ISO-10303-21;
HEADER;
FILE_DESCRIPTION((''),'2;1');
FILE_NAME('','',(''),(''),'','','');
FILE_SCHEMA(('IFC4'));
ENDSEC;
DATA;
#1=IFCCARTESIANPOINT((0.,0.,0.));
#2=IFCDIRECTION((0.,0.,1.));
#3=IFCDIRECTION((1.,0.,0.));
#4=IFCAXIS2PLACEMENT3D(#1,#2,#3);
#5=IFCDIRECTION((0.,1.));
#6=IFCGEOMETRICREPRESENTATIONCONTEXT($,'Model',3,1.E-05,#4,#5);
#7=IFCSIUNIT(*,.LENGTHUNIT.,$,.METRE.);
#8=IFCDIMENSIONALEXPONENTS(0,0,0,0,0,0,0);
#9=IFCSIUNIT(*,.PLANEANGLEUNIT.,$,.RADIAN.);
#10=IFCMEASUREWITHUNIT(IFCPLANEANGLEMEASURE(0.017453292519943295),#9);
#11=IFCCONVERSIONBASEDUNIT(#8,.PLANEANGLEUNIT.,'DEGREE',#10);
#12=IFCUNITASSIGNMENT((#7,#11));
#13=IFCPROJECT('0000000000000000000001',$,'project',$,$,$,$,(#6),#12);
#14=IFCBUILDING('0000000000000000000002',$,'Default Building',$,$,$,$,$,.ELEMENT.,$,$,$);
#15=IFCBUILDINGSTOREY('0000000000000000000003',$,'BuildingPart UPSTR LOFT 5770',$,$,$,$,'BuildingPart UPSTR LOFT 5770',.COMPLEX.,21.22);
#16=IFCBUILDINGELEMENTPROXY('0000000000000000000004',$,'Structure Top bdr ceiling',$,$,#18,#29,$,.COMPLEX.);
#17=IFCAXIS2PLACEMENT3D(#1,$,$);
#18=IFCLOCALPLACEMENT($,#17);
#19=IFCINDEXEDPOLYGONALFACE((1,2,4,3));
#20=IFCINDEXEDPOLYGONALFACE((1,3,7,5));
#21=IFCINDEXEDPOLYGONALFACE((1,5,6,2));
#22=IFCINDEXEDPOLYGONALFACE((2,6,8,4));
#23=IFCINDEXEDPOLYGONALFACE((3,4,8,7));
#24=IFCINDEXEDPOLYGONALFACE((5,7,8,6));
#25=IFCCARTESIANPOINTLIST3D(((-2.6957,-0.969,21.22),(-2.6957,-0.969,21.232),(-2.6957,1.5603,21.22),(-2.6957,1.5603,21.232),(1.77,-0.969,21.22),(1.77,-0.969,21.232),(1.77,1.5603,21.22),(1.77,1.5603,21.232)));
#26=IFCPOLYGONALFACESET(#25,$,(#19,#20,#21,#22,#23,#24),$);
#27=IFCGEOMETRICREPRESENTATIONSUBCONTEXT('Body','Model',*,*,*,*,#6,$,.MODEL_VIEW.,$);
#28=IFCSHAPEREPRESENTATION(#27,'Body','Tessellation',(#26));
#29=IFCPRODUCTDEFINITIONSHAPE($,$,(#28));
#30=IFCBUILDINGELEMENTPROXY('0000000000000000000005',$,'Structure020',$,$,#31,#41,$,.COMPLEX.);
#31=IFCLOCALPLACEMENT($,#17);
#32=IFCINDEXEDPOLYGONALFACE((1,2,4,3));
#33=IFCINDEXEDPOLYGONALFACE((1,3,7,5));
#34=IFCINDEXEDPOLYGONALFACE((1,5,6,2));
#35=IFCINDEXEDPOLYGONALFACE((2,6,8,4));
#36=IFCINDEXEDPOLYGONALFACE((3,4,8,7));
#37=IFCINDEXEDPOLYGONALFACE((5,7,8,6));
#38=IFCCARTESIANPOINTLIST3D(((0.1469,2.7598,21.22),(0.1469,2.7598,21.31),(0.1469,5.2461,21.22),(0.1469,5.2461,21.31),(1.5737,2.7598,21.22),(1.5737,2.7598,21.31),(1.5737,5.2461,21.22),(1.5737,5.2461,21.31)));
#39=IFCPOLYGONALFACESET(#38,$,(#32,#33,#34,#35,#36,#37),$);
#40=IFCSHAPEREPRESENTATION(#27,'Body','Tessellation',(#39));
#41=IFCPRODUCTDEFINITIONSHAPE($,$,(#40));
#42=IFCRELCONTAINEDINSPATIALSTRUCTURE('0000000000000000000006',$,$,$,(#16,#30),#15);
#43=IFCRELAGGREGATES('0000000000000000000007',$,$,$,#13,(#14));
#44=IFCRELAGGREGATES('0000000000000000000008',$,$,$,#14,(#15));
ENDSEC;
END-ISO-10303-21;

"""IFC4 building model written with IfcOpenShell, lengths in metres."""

from ifc_helpers import new_model, entity, si_unit, converted_unit, direction, frame, origin_with_axes, origin_2d_with_axis, place, context, subcontext, project, spatial, rectangle, extrude, element, save


model = new_model("IFC4")

# Units and contexts
model_context = context("Model", 3, precision=1e-05, world=origin_with_axes(), true_north=direction((0.0, 1.0)))
body_context = subcontext(model_context, "Body", "Model", "MODEL_VIEW")
ifc_project = project(units=[si_unit("LENGTHUNIT", "METRE"), converted_unit("PLANEANGLEUNIT", "DEGREE", entity("IfcPlaneAngleMeasure", 0.017453292519943295), si_unit("PLANEANGLEUNIT", "RADIAN"), dimensions=[0, 0, 0, 0, 0, 0, 0])], contexts=[model_context])

# Building, storey
building = spatial("IfcBuilding", under=ifc_project, Name="Default Building", CompositionType="ELEMENT")
storey = spatial("IfcBuildingStorey", under=building, Name="BuildingPart UPSTR LOFT 5770", LongName="BuildingPart UPSTR LOFT 5770", CompositionType="COMPLEX", Elevation=21.22)

# Building element proxies
placement = place(None, origin_with_axes())
element("IfcBuildingElementProxy", 1, at=placement, inside=storey, Name="Structure Top bdr ceiling", PredefinedType="COMPLEX", context=body_context, shape_type="SweptSolid", body=[
    extrude(rectangle(XDim=4.4658, YDim=2.5293, at=origin_2d_with_axis()), frame((-0.4629, 0.2956, 21.22), z_axis=(0.0, 0.0, 1.0), x_axis=(1.0, 0.0, 0.0)), (0.0, 0.0, 1.0), 0.012),
])
element("IfcBuildingElementProxy", 2, at=placement, inside=storey, Name="Structure020", PredefinedType="COMPLEX", context=body_context, shape_type="SweptSolid", body=[
    extrude(rectangle(XDim=1.4268, YDim=2.4862, at=origin_2d_with_axis()), frame((0.8603, 4.0029, 21.22), z_axis=(0.0, 0.0, 1.0), x_axis=(1.0, 0.0, 0.0)), (0.0, 0.0, 1.0), 0.09),
])

save(model, "model.ifc")
